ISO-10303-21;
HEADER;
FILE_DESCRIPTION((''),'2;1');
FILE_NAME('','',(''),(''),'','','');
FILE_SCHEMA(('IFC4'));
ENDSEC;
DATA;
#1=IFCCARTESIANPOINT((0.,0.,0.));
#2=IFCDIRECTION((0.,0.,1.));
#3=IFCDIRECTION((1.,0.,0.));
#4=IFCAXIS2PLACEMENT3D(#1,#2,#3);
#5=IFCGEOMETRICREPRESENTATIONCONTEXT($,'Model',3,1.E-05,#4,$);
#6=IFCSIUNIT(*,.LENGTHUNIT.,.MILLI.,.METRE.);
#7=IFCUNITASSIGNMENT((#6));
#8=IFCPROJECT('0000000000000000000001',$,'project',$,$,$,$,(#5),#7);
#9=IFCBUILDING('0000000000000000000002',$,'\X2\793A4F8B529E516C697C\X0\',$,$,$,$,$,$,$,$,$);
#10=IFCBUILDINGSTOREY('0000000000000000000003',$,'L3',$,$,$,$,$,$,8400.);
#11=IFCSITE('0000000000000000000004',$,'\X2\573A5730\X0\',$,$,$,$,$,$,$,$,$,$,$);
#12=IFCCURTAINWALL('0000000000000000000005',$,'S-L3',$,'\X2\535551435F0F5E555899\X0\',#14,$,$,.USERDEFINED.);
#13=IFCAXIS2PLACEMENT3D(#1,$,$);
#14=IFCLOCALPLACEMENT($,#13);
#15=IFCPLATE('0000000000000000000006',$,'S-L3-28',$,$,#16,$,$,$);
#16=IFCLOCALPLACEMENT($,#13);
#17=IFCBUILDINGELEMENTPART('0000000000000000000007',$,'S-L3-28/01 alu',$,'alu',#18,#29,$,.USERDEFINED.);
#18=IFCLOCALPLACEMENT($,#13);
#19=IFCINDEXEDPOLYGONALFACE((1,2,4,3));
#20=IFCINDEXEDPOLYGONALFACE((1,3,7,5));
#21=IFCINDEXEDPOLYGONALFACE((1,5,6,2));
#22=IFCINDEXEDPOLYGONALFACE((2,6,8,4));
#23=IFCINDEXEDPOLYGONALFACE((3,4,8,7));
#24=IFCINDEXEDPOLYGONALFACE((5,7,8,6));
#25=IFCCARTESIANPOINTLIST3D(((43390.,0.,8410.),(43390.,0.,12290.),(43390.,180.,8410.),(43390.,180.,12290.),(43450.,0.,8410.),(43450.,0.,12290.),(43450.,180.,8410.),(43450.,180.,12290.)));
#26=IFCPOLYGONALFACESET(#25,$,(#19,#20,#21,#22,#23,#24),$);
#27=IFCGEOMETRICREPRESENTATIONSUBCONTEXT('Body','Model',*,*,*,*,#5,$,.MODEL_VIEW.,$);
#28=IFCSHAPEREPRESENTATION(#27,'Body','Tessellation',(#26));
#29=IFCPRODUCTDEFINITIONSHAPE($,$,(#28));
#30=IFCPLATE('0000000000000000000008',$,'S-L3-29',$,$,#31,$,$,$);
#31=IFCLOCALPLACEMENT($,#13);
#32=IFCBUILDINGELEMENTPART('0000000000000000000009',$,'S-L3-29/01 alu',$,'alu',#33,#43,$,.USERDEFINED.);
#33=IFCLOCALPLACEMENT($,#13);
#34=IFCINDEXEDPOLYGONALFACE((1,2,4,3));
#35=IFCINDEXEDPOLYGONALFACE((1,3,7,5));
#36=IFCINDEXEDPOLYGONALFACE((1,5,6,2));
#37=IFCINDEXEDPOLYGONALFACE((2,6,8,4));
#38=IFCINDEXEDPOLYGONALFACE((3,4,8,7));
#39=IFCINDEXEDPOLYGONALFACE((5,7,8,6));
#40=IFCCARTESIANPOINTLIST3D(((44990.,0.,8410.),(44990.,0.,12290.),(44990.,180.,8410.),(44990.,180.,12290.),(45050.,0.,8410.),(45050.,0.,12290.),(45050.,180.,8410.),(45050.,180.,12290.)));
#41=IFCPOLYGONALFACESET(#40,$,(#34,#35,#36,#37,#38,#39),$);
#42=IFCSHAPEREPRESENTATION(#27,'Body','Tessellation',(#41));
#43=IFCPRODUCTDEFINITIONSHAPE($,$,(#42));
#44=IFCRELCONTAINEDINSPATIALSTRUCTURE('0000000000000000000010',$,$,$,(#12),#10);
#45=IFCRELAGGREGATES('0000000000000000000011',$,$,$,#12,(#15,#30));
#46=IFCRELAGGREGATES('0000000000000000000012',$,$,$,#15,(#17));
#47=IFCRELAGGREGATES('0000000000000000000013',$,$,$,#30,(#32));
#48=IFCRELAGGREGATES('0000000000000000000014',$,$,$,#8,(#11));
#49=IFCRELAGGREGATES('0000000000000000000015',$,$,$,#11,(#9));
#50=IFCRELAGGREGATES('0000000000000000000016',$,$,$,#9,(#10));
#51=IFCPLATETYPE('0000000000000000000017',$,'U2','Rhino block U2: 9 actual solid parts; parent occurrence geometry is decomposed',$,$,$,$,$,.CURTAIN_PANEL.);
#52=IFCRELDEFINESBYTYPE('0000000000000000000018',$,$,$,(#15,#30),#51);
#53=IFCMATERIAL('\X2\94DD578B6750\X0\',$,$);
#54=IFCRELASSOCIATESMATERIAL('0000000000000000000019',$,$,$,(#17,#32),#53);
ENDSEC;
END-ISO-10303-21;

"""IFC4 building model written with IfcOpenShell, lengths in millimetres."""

from ifc_helpers import new_model, si_unit, frame, frame_2d, origin, origin_with_axes, place, context, subcontext, project, spatial, rectangle, extrude, source, transform, mapped, material, type_object, element, aggregate, save


model = new_model("IFC4")

# Units and contexts
model_context = context("Model", 3, precision=1e-05, world=origin_with_axes())
body_context = subcontext(model_context, "Body", "Model", "MODEL_VIEW")
ifc_project = project(units=[si_unit("LENGTHUNIT", "METRE", prefix="MILLI")], contexts=[model_context])

# Site, building, storey
site = spatial("IfcSite", under=ifc_project, Name="场地")
building = spatial("IfcBuilding", under=site, Name="示例办公楼")
storey = spatial("IfcBuildingStorey", under=building, Name="L3", Elevation=8400.0)

# Curtain wall, plates, building element parts
curtain_wall = element("IfcCurtainWall", 1, inside=storey, Name="S-L3", ObjectType="单元式幕墙", PredefinedType="USERDEFINED")
plate_type = type_object("IfcPlateType", Name="U2", Description="Rhino block U2: 9 actual solid parts; parent occurrence geometry is decomposed", PredefinedType="CURTAIN_PANEL")
plate_1_placement = place(None, frame((43390.0, 0.0, 8410.0), z_axis=(0.0, 0.0, 1.0), x_axis=(1.0, 0.0, 0.0)))
plate_1 = element("IfcPlate", 2, at=plate_1_placement, type_object=plate_type, Name="S-L3-28")
ifc_material_1 = material(Name="铝型材")
shared_shape_1 = source(origin(), body_context, "Body", "SweptSolid", [
    extrude(rectangle(XDim=60.0, YDim=180.0, at=frame_2d((30.0, 90.0))), origin(), (0.0, 0.0, 1.0), 3880.0),
])
building_element_part_1_placement = place(plate_1_placement, origin())
building_element_part_1 = element("IfcBuildingElementPart", 3, at=building_element_part_1_placement, material=ifc_material_1, Name="S-L3-28/01 alu", ObjectType="alu", PredefinedType="USERDEFINED", context=body_context, shape_type="MappedRepresentation", body=[
    mapped(shared_shape_1, transform((0.0, 0.0, 0.0))),
])
plate_2_placement = place(None, frame((44990.0, 0.0, 8410.0), z_axis=(0.0, 0.0, 1.0), x_axis=(1.0, 0.0, 0.0)))
plate_2 = element("IfcPlate", 4, at=plate_2_placement, type_object=plate_type, Name="S-L3-29")
building_element_part_2_placement = place(plate_2_placement, origin())
building_element_part_2 = element("IfcBuildingElementPart", 5, at=building_element_part_2_placement, material=ifc_material_1, Name="S-L3-29/01 alu", ObjectType="alu", PredefinedType="USERDEFINED", context=body_context, shape_type="MappedRepresentation", body=[
    mapped(shared_shape_1, transform((0.0, 0.0, 0.0))),
])
aggregate(curtain_wall, [plate_1, plate_2])
aggregate(plate_1, [building_element_part_1])
aggregate(plate_2, [building_element_part_2])

save(model, "model.ifc")
